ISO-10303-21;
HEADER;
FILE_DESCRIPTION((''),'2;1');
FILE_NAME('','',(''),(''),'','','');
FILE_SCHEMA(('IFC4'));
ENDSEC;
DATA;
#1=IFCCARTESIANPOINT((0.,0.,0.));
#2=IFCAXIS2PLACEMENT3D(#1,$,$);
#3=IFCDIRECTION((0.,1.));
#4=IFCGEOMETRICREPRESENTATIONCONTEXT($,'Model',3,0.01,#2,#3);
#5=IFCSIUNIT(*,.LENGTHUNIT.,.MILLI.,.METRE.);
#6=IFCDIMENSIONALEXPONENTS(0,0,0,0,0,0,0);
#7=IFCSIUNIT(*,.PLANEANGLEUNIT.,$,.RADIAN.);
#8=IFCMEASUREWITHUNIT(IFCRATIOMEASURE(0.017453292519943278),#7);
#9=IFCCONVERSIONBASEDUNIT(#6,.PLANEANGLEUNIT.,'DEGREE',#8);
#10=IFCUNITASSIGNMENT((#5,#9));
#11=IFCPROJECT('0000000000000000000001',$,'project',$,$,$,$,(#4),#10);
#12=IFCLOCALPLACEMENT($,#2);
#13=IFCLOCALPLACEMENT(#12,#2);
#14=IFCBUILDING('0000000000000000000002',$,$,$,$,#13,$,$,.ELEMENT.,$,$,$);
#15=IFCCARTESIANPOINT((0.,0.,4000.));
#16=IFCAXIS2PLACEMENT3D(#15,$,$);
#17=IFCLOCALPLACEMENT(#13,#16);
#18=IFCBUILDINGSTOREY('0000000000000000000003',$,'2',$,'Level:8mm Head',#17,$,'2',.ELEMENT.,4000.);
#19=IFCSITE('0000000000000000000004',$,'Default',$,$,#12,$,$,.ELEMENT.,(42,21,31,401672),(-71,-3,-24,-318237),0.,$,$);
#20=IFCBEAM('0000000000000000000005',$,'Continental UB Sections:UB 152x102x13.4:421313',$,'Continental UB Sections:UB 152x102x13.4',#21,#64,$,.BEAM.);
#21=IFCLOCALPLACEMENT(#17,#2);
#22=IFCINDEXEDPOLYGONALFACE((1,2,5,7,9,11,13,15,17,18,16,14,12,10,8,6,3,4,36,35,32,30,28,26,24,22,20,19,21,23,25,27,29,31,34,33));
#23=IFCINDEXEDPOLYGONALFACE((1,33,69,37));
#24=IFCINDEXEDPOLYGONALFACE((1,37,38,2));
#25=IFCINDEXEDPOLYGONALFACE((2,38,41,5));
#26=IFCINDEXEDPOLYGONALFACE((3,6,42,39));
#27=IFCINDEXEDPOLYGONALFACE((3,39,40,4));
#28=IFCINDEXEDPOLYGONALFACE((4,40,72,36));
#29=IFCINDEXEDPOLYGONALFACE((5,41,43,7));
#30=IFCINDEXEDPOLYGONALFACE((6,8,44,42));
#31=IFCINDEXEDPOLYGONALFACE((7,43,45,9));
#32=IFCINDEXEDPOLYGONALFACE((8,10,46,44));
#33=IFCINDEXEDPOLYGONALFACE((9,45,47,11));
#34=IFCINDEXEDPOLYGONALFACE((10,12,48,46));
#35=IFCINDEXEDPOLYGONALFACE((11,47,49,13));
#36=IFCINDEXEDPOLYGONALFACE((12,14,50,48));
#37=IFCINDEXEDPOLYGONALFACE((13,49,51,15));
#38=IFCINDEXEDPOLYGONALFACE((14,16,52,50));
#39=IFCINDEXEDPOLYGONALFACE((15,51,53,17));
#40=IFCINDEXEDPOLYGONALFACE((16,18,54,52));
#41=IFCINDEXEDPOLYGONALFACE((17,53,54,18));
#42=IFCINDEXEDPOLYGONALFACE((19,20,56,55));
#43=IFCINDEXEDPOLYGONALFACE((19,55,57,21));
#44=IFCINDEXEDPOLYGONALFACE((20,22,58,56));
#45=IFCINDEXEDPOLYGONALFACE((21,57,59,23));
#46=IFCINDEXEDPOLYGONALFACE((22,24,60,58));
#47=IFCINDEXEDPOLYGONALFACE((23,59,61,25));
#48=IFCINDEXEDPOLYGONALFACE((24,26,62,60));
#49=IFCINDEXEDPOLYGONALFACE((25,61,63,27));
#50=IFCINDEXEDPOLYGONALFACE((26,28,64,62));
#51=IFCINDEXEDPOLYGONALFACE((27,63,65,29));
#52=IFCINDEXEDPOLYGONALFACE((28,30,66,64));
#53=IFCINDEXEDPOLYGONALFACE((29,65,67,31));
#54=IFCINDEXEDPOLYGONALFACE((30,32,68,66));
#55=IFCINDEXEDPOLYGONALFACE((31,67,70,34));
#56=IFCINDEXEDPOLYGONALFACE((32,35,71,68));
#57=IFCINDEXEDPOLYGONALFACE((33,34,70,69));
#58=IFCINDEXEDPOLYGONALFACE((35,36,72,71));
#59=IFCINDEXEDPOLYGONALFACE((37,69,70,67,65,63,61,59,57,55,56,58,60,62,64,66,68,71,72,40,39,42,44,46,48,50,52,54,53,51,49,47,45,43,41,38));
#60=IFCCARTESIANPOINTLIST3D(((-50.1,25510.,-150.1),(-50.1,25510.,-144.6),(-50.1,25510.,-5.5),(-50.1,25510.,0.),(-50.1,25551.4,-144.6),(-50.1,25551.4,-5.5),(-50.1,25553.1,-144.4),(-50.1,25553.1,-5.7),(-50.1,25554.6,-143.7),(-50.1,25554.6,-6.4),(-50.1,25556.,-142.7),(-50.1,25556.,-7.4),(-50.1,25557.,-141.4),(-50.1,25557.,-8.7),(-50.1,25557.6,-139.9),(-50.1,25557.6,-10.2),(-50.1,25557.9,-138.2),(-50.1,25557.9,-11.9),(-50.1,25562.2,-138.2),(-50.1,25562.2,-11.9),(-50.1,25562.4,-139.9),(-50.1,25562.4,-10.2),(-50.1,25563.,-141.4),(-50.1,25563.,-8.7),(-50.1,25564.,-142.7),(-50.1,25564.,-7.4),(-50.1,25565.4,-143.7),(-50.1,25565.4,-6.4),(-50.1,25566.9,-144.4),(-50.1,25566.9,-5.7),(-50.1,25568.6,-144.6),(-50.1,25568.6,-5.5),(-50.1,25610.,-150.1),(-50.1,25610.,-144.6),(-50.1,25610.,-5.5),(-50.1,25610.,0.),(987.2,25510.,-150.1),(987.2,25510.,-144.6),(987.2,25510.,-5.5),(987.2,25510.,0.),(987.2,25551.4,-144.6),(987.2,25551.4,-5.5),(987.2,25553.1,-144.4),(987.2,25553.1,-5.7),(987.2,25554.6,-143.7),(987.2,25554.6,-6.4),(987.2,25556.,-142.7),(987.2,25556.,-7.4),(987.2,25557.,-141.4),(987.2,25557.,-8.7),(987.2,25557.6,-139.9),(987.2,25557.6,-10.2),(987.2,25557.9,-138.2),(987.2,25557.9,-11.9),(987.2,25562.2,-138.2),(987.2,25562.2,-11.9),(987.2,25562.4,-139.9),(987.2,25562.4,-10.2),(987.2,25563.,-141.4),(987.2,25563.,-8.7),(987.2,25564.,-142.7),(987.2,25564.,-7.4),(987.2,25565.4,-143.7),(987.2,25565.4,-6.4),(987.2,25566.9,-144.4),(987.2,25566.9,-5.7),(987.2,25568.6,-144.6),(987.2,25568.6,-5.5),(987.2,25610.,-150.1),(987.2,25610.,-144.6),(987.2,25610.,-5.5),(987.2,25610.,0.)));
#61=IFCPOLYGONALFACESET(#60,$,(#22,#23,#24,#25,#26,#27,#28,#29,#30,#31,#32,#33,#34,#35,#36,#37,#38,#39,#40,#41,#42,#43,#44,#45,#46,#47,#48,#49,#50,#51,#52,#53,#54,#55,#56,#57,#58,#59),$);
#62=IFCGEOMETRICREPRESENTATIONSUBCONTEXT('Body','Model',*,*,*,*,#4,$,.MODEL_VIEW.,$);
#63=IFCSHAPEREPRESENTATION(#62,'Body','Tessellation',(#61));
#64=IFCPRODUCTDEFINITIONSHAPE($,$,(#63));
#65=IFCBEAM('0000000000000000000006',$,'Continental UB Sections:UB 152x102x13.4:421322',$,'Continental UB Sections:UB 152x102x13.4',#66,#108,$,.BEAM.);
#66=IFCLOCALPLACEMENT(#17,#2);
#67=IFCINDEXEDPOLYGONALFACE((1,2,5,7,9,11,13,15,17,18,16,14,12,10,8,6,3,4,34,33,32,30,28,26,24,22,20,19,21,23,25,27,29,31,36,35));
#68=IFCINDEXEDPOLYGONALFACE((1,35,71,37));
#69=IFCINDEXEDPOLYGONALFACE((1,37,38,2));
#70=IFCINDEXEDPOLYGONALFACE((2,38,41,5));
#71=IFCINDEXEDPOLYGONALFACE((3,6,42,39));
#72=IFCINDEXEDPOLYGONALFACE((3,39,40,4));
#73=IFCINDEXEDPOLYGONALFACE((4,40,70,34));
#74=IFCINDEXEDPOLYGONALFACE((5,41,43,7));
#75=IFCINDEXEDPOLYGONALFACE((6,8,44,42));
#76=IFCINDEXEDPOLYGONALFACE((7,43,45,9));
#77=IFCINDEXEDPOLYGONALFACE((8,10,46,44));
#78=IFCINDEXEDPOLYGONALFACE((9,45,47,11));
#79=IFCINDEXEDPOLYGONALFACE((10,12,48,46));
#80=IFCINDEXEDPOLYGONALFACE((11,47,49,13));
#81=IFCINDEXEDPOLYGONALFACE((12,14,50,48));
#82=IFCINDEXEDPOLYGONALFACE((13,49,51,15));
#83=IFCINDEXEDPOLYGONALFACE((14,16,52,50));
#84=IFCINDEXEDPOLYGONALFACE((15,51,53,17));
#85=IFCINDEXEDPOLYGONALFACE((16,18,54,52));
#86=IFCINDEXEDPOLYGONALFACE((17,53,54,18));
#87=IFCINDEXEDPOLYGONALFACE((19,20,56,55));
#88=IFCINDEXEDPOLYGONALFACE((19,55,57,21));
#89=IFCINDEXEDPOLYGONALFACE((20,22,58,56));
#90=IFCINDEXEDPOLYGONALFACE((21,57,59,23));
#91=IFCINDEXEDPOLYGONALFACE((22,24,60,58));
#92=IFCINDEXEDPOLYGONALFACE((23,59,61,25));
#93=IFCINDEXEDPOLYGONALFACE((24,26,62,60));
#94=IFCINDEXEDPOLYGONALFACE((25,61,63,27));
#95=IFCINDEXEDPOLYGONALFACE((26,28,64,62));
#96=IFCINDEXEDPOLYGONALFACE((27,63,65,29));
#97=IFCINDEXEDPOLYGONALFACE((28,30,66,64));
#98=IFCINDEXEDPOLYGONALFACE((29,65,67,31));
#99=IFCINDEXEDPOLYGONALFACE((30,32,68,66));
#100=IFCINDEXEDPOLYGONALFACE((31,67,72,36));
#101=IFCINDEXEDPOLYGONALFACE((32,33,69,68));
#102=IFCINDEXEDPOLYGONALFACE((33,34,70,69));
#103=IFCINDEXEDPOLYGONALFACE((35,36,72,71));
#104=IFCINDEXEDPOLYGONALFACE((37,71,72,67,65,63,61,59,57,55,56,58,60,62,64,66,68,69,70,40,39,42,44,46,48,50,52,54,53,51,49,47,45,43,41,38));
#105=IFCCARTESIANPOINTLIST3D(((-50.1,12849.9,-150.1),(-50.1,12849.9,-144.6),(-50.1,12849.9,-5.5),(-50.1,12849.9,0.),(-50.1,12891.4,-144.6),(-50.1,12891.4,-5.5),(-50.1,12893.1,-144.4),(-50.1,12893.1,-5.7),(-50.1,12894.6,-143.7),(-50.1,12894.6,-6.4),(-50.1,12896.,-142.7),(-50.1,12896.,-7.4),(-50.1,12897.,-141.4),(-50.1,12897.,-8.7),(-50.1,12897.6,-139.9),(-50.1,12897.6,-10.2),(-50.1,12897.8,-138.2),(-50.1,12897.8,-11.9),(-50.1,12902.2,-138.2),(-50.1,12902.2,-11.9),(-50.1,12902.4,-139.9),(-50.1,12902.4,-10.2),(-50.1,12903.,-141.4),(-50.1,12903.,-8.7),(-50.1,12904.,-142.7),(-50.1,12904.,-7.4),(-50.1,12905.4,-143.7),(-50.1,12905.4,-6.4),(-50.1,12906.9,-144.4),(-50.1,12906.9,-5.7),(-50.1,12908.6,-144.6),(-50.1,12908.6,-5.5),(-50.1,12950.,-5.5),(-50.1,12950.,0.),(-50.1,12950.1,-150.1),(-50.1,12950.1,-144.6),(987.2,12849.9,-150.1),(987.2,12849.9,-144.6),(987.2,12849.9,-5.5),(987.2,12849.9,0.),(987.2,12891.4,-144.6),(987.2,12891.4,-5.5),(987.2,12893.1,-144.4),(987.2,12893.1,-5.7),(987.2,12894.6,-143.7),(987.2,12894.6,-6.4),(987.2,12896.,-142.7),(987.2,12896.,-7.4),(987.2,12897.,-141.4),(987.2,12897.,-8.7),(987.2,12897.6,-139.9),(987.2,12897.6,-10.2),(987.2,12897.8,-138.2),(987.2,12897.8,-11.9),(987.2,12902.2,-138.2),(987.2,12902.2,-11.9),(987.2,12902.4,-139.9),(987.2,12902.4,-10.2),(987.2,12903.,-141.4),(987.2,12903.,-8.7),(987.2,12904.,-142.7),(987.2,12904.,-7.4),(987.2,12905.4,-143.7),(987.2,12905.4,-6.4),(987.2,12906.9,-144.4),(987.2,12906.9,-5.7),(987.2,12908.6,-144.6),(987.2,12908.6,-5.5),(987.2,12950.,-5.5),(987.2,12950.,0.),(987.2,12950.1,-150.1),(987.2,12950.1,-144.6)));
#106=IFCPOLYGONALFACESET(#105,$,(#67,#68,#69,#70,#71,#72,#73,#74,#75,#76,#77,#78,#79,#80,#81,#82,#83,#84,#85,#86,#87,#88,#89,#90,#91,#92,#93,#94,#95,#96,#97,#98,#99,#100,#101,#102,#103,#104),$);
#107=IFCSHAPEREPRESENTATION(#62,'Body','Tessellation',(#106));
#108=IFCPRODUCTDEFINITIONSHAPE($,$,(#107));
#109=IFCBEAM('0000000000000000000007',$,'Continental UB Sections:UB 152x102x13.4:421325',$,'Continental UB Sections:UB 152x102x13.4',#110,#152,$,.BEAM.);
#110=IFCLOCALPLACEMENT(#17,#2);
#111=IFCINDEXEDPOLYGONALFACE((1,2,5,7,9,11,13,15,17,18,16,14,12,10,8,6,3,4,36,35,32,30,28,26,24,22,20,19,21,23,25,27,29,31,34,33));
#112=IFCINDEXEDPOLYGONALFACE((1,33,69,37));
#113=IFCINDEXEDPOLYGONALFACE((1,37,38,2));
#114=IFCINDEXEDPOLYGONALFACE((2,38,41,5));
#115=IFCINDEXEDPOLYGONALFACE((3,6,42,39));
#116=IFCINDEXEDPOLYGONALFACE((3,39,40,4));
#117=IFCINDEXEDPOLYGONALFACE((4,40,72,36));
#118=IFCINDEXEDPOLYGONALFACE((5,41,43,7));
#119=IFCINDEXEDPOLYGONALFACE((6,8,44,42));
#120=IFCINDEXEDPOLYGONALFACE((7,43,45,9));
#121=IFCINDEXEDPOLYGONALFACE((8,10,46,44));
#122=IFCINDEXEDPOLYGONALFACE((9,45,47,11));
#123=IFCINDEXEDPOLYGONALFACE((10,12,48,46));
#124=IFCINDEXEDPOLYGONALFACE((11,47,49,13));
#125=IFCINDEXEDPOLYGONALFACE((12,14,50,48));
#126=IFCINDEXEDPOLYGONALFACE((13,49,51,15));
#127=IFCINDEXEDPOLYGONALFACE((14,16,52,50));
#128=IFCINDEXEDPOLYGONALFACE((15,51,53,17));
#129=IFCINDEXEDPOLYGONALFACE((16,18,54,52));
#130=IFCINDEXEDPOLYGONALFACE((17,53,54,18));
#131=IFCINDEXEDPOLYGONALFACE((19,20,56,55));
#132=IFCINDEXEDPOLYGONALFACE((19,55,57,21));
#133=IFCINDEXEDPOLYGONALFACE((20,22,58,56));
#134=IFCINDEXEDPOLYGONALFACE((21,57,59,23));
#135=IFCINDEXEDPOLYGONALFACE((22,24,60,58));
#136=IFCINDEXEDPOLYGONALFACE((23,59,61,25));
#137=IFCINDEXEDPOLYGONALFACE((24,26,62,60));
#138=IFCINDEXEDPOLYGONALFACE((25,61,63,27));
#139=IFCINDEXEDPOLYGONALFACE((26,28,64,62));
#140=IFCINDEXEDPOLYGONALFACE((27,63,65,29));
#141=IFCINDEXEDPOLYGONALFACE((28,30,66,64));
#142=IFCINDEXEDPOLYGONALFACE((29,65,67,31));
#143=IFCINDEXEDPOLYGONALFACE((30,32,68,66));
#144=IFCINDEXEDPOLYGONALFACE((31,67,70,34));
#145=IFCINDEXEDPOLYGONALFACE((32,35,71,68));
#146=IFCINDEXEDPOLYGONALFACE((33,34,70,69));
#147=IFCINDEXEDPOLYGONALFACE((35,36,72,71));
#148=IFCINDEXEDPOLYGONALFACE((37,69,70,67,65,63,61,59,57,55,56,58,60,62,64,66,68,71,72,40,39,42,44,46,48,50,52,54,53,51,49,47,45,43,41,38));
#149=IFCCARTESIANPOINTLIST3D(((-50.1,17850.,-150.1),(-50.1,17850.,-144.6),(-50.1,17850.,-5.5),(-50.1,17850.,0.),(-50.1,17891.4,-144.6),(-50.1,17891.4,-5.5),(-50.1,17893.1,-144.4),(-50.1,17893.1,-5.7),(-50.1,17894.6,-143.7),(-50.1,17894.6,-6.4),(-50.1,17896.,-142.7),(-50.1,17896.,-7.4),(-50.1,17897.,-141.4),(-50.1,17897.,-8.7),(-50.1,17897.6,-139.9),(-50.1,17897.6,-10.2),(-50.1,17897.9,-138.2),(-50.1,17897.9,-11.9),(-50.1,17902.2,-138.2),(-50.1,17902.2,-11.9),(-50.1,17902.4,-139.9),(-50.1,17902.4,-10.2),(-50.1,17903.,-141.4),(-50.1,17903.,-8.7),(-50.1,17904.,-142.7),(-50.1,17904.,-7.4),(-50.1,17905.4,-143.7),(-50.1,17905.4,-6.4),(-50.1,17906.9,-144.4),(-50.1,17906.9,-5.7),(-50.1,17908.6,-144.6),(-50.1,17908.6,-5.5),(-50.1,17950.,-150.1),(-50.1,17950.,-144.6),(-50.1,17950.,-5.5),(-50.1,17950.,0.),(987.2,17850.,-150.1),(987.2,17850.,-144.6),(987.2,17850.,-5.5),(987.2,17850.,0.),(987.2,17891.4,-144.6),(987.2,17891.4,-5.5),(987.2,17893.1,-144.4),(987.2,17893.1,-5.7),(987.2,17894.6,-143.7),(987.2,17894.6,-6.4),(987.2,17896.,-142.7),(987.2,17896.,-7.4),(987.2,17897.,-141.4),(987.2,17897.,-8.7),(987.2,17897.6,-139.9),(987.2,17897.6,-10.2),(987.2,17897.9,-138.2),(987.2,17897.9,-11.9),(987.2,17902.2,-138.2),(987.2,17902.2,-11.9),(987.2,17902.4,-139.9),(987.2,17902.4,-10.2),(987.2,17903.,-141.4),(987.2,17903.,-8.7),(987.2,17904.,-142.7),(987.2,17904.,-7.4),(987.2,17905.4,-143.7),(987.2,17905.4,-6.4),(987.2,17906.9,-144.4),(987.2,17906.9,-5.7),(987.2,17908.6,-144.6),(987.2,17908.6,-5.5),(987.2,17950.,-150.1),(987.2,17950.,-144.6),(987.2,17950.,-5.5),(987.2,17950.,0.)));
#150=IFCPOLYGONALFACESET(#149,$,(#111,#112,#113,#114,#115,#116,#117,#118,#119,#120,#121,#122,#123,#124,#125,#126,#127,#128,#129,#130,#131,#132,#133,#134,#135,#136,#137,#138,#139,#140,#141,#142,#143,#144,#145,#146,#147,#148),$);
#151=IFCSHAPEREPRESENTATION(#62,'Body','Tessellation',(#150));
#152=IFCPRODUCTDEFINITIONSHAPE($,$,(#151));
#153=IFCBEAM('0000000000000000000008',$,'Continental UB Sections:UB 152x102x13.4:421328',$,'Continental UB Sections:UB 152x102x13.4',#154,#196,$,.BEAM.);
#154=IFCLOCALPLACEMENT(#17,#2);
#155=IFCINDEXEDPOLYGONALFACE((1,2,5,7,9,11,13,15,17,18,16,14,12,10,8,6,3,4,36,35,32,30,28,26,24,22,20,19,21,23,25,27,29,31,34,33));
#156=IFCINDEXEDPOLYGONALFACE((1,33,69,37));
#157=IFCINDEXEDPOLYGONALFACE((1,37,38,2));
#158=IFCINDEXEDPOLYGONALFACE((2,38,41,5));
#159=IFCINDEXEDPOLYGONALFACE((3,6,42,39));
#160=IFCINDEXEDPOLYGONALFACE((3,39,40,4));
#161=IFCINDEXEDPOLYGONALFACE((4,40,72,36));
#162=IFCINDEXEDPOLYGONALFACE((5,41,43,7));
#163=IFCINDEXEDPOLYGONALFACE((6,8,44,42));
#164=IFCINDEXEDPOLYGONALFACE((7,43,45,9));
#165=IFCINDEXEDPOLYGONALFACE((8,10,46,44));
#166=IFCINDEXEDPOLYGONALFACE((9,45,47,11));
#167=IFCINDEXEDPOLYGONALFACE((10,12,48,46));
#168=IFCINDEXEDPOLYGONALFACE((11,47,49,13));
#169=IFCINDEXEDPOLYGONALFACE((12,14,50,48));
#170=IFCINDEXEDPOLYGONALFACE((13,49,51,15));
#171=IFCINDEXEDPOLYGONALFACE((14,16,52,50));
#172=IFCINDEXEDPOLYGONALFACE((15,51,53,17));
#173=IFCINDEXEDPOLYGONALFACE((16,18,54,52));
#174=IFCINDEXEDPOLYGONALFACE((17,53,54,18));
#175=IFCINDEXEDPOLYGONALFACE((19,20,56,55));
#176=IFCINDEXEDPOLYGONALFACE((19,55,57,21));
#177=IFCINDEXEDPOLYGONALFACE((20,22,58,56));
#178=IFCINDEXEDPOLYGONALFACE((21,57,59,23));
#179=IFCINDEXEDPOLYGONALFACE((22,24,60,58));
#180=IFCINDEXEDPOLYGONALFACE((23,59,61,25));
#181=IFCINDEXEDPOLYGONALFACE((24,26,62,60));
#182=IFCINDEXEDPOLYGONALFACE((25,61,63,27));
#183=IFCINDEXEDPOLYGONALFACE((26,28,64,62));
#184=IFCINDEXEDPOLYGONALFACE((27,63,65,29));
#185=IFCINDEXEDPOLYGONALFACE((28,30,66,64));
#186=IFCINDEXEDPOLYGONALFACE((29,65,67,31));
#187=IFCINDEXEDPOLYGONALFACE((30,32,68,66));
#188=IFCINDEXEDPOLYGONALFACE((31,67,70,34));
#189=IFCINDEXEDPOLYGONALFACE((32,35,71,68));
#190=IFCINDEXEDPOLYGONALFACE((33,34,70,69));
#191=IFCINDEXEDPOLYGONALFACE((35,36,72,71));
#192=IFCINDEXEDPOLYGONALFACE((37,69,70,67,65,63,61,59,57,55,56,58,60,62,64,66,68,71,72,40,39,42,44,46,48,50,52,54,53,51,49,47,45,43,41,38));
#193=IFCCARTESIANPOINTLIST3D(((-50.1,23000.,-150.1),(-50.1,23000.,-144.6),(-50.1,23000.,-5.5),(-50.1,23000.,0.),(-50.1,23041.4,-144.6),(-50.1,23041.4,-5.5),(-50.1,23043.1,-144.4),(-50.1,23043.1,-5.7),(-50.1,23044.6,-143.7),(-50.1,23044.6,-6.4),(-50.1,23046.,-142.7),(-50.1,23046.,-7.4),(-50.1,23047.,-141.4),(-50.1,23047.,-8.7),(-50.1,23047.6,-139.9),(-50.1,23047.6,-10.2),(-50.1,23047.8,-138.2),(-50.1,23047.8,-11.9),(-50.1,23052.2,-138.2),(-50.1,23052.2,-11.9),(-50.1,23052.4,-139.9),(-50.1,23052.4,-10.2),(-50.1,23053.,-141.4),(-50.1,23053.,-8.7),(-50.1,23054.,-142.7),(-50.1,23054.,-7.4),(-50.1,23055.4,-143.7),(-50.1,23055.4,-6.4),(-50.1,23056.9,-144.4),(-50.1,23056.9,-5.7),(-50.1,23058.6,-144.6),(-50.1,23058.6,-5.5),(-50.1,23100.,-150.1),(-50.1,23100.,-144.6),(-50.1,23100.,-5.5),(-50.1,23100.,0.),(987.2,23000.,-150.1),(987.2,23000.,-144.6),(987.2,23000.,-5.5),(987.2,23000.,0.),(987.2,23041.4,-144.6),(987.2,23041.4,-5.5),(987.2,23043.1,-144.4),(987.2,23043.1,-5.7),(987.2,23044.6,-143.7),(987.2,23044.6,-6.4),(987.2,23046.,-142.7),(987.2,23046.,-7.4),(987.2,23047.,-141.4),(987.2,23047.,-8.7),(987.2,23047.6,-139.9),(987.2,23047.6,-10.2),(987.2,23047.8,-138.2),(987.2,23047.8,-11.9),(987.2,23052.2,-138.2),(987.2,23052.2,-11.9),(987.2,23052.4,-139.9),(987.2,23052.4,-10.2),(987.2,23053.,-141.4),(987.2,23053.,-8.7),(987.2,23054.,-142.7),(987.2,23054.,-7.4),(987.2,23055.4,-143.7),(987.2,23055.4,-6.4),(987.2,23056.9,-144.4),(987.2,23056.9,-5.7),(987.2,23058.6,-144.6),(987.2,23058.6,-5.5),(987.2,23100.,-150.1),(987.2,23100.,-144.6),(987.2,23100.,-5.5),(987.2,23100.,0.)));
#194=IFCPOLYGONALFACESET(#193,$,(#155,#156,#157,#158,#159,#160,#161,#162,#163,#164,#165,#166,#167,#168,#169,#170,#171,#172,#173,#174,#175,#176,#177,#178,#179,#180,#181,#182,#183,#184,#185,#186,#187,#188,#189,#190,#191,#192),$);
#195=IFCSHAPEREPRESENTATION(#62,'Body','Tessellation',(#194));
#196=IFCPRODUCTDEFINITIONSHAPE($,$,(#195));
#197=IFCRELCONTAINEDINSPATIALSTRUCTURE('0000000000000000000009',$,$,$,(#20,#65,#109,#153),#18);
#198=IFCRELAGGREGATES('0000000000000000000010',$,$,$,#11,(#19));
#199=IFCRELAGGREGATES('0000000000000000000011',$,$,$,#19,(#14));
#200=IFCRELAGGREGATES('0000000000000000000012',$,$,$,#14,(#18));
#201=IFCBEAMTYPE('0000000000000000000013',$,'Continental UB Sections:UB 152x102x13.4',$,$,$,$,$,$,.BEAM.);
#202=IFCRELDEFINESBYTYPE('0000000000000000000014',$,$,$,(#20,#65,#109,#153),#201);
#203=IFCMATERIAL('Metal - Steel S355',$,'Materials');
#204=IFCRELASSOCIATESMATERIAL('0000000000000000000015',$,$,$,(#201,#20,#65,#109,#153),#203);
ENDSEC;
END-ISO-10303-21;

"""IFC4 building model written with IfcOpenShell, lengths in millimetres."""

from ifc_helpers import new_model, entity, si_unit, converted_unit, direction, frame, origin, place, context, subcontext, project, spatial, line, arc, indexed_curve, outline, extrude, source, transform, mapped, material, type_object, type_shapes, element, save


model = new_model("IFC4")

# Units and contexts
model_context = context("Model", 3, precision=0.01, world=origin(), true_north=direction((0.0, 1.0)))
body_context = subcontext(model_context, "Body", "Model", "MODEL_VIEW")
ifc_project = project(units=[si_unit("LENGTHUNIT", "METRE", prefix="MILLI"), converted_unit("PLANEANGLEUNIT", "DEGREE", entity("IfcRatioMeasure", 0.017453292519943278), si_unit("PLANEANGLEUNIT", "RADIAN"), dimensions=[0, 0, 0, 0, 0, 0, 0])], contexts=[model_context])

# Site, building, storey
site_placement = place(None, origin())
site = spatial("IfcSite", under=ifc_project, at=site_placement, Name="Default", CompositionType="ELEMENT", RefLatitude=(42, 21, 31, 401672), RefLongitude=(-71, -3, -24, -318237), RefElevation=0.0)
building_placement = place(site_placement, origin())
building = spatial("IfcBuilding", under=site, at=building_placement, CompositionType="ELEMENT")
storey_placement = place(building_placement, frame((0.0, 0.0, 4000.0)))
storey = spatial("IfcBuildingStorey", under=building, at=storey_placement, Name="2", ObjectType="Level:8mm Head", LongName="2", CompositionType="ELEMENT", Elevation=4000.0)

# Beams
ifc_material_1 = material(Name="Metal - Steel S355", Category="Materials")
beam_type_1 = type_object("IfcBeamType", Name="Continental UB Sections:UB 152x102x13.4", PredefinedType="BEAM", material=ifc_material_1)
shared_shape_1 = source(origin(), body_context, "Body", "SweptSolid", [
    extrude(outline(indexed_curve([(-75.0, -50.1), (-69.6, -50.1), (-69.6, -8.5), (-67.7, -4.0), (-63.2, -2.1), (63.1, -2.1), (67.7, -4.0), (69.5, -8.5), (69.5, -50.1), (75.1, -50.1), (75.1, 50.1), (69.5, 50.1), (69.5, 8.6), (67.7, 4.0), (63.1, 2.2), (-63.2, 2.2), (-67.7, 4.0), (-69.6, 8.6), (-69.6, 50.0), (-75.0, 50.0)], segments=[line(1, 2, 3), arc(3, 4, 5), line(5, 6), arc(6, 7, 8), line(8, 9, 10, 11, 12, 13), arc(13, 14, 15), line(15, 16), arc(16, 17, 18), line(18, 19, 20, 1)], self_intersect=False)), frame((-550.1, 0.0, 0.0), z_axis=(1.0, 0.0, 0.0), x_axis=(0.0, 0.0, -1.0)), (0.0, 0.0, 1.0), 1037.3),
])
type_shapes(beam_type_1, [shared_shape_1])
for number, where, name in (
    (1, (500.0, 25560.0, -75.1), "Continental UB Sections:UB 152x102x13.4:421313"),
    (2, (500.0, 12900.0, -75.1), "Continental UB Sections:UB 152x102x13.4:421322"),
    (3, (500.0, 17900.0, -75.1), "Continental UB Sections:UB 152x102x13.4:421325"),
    (4, (500.0, 23050.0, -75.1), "Continental UB Sections:UB 152x102x13.4:421328"),
):
    element("IfcBeam", number, at=place(storey_placement, frame(where)), inside=storey, type_object=beam_type_1, material=ifc_material_1, Name=name, ObjectType="Continental UB Sections:UB 152x102x13.4", PredefinedType="BEAM", context=body_context, shape_type="MappedRepresentation", body=[
        mapped(shared_shape_1, transform((0.0, 0.0, 0.0), scale=1.0)),
    ])

save(model, "model.ifc")
